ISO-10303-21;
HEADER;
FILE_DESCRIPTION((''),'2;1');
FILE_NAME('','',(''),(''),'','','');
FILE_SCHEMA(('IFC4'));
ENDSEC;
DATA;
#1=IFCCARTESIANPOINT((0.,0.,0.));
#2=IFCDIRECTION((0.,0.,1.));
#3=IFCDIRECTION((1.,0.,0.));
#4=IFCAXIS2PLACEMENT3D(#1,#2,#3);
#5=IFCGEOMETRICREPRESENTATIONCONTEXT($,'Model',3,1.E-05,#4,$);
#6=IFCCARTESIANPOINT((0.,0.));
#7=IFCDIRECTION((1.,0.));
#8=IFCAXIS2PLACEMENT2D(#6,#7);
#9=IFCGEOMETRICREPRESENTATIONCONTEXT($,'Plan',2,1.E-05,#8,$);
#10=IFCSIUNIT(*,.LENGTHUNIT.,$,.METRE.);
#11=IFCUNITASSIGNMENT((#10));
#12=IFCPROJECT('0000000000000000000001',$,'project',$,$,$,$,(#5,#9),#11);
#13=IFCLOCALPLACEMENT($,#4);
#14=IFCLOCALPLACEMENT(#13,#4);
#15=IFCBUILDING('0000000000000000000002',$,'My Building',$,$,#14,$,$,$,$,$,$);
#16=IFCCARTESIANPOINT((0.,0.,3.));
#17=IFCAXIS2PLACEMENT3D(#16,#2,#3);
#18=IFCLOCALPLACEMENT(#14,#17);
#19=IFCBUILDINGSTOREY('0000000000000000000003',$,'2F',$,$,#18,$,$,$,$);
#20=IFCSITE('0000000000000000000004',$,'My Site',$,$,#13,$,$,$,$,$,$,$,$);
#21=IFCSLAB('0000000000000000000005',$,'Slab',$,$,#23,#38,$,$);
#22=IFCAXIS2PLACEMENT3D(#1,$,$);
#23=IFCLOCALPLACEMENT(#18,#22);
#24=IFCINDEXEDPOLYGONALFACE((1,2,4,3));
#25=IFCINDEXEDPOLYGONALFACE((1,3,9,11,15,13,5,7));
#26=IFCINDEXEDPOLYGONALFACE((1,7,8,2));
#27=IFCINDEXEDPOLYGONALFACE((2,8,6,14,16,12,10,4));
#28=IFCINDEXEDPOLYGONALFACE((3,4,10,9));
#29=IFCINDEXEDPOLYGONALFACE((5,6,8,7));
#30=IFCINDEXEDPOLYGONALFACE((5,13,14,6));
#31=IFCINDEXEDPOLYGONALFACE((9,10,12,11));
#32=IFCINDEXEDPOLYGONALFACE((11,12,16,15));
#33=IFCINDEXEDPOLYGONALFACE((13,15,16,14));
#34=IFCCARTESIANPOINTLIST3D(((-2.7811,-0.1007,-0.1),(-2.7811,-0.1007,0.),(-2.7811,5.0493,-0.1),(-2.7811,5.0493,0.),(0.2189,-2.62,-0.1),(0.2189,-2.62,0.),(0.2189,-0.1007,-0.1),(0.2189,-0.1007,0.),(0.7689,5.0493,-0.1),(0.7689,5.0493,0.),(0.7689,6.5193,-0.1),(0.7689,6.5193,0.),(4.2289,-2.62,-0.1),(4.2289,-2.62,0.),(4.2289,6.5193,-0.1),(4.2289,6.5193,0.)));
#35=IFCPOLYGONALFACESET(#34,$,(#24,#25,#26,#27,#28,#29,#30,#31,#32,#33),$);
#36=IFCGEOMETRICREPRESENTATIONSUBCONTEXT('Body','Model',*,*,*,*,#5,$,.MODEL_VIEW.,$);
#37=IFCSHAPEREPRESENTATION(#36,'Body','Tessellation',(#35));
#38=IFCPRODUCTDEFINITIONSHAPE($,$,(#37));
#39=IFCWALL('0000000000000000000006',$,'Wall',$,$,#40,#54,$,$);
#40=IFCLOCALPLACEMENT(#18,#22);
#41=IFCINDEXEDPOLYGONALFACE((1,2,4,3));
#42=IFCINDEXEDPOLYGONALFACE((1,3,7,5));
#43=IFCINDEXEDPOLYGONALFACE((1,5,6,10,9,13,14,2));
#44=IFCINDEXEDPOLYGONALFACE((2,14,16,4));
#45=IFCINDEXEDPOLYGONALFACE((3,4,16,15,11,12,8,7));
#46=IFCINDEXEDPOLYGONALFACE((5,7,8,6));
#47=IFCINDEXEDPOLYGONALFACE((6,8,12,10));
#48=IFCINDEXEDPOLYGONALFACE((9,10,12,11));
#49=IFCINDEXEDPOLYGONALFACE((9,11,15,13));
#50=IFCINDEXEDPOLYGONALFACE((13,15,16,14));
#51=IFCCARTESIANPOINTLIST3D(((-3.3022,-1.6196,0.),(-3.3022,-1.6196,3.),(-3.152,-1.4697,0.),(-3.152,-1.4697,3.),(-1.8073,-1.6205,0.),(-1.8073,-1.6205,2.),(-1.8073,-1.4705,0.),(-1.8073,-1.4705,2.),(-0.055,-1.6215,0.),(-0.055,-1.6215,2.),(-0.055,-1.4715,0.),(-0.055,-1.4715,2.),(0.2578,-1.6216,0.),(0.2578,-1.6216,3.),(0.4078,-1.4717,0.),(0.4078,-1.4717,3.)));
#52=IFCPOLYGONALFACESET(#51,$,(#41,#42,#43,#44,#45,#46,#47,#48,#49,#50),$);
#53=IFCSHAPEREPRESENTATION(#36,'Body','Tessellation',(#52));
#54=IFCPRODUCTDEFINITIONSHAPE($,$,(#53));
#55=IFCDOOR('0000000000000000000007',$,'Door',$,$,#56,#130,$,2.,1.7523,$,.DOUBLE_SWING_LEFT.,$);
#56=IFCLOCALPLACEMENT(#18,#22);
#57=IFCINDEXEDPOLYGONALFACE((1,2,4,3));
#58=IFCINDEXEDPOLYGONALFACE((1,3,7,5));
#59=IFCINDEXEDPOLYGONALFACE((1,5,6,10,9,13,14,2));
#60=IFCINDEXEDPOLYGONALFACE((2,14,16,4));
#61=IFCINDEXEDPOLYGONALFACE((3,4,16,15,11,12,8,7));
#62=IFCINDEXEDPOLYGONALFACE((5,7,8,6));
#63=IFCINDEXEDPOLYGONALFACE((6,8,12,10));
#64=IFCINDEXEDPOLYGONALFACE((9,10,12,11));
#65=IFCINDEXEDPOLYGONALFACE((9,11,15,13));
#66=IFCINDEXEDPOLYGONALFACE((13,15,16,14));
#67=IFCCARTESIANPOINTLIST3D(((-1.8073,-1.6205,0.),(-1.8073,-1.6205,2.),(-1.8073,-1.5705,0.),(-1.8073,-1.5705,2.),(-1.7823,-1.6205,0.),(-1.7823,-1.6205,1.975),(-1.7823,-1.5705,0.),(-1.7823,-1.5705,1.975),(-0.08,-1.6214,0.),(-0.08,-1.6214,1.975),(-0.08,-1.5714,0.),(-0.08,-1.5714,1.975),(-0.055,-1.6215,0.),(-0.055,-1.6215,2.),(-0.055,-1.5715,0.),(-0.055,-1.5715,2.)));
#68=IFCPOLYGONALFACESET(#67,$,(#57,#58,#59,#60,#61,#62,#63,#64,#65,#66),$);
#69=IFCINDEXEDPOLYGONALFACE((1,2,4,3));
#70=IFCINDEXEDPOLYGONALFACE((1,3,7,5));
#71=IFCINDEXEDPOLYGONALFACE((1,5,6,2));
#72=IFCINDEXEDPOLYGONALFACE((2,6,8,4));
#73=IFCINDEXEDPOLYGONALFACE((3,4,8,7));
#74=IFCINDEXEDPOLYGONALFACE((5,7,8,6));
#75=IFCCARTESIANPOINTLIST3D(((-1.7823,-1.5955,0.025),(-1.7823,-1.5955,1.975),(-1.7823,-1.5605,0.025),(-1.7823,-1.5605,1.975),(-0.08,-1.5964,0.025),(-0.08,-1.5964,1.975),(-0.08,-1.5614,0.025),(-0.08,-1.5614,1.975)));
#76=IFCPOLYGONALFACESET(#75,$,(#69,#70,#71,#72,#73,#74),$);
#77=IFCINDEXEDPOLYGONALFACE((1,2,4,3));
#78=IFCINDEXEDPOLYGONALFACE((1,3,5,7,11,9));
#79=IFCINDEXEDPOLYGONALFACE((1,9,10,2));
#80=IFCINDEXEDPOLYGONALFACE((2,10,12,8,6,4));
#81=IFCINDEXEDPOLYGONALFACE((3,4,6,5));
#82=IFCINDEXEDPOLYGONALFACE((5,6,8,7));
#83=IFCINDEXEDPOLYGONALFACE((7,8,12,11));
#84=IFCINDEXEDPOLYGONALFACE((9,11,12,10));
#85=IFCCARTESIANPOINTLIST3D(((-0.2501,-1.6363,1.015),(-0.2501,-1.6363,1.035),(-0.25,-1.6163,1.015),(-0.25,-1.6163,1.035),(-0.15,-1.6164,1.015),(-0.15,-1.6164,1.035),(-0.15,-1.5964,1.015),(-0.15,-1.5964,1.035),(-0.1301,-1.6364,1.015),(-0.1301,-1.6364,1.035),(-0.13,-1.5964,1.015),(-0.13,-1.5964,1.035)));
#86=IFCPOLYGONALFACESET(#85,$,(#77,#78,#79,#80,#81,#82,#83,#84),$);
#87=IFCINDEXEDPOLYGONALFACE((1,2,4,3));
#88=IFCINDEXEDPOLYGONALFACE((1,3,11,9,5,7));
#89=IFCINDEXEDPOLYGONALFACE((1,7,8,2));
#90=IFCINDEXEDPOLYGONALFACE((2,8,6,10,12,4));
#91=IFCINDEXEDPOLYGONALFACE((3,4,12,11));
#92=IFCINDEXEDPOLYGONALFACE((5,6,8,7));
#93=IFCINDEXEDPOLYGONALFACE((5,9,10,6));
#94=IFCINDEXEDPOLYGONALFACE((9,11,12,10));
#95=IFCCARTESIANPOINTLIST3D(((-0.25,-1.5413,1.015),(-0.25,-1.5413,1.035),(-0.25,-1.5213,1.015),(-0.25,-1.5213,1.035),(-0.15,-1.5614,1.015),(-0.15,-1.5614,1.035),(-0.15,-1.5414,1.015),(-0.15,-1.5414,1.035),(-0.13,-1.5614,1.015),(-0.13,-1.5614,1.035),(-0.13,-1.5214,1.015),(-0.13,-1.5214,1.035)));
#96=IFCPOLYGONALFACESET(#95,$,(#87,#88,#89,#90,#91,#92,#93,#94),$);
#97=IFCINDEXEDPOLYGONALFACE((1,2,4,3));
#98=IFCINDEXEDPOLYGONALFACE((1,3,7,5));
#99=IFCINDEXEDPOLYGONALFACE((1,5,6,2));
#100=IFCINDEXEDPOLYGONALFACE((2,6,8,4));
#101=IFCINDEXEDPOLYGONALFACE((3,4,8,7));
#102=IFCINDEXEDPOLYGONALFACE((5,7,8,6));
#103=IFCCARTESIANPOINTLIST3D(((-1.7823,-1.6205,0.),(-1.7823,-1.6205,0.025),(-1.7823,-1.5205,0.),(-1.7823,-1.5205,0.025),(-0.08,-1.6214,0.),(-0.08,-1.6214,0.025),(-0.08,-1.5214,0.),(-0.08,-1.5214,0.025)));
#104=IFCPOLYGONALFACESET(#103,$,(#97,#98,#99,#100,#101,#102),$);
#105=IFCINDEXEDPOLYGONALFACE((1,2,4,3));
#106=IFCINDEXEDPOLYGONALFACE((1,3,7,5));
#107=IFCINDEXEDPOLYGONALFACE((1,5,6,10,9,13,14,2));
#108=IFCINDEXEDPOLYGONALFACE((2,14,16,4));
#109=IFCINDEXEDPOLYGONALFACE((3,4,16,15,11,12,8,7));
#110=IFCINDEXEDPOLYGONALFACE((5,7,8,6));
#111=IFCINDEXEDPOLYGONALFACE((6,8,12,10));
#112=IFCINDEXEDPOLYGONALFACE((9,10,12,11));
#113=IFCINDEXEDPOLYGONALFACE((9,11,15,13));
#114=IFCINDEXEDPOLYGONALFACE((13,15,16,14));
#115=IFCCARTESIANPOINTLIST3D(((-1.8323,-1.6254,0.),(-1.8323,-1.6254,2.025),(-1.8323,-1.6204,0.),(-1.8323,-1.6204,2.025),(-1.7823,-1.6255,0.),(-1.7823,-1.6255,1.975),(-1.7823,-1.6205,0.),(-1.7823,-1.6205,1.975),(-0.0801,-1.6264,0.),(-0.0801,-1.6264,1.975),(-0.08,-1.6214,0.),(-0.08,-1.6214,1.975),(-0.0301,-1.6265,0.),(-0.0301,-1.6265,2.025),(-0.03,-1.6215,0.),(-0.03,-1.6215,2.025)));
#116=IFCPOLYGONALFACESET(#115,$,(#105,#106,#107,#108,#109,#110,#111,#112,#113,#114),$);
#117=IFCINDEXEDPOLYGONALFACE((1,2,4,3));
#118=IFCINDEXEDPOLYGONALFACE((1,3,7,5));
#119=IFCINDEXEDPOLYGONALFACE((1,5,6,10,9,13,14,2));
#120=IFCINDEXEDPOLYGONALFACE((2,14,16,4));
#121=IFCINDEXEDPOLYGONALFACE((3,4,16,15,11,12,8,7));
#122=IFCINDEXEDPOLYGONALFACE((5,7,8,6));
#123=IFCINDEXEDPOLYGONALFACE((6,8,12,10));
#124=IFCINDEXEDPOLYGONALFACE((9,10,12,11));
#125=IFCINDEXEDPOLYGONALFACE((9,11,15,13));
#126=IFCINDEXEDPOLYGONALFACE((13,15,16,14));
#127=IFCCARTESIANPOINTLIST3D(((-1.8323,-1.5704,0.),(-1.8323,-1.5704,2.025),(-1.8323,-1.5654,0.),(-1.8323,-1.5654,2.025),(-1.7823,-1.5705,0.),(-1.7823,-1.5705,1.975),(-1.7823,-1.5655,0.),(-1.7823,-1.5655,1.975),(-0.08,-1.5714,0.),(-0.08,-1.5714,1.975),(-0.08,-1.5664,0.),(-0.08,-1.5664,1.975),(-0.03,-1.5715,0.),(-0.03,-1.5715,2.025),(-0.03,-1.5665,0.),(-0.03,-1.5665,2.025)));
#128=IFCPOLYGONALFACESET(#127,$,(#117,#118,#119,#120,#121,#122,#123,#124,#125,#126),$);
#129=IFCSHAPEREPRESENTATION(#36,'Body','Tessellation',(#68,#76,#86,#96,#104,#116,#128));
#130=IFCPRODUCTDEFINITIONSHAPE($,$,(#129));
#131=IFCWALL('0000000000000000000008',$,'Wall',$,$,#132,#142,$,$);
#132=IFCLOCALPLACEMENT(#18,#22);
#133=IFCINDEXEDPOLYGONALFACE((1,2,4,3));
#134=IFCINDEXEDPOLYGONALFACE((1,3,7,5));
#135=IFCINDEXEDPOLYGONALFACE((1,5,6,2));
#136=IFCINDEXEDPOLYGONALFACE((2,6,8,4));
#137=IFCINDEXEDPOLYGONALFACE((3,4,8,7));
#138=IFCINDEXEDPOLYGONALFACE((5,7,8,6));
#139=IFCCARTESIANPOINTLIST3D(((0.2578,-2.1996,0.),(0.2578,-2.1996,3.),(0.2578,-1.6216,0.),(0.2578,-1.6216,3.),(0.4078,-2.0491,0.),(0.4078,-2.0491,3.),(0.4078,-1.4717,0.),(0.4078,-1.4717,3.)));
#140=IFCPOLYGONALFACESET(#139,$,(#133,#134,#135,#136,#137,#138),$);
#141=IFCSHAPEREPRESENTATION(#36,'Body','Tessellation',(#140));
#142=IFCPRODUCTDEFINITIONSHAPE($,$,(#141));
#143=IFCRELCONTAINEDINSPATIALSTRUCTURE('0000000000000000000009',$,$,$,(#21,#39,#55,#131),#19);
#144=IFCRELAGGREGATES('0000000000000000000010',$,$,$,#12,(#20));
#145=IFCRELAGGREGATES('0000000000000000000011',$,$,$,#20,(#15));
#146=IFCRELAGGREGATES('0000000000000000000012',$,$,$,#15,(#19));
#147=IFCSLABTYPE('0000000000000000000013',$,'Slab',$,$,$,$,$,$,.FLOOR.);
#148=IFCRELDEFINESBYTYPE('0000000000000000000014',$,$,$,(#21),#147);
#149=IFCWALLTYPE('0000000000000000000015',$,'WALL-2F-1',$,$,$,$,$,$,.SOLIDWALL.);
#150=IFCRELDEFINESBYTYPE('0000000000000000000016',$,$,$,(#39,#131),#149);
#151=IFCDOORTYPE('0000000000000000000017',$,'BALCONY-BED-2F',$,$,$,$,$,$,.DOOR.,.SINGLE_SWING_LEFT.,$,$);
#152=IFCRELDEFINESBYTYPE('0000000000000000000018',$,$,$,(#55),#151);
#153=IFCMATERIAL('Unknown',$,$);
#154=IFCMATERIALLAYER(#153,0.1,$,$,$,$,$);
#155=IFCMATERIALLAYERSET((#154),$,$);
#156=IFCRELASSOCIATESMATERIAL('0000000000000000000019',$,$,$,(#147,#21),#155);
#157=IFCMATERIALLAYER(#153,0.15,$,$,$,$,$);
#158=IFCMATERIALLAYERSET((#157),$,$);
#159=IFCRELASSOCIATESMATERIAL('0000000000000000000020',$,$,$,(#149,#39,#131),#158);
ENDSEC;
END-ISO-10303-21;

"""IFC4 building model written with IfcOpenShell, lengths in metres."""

from ifc_helpers import new_model, entity, si_unit, frame, origin_with_axes, origin_2d_with_axis, place, context, subcontext, project, spatial, line, indexed_curve, outline, extrude, shape, source, transform, mapped, material, layer, layer_set, layer_usage, type_object, type_shapes, element, fill, save


model = new_model("IFC4")

# Units and contexts
model_context = context("Model", 3, precision=1e-05, world=origin_with_axes())
plan_context = context("Plan", 2, precision=1e-05, world=origin_2d_with_axis())
body_context_1 = subcontext(model_context, "Body", "Model", "MODEL_VIEW")
body_context_2 = subcontext(plan_context, "Body", "Plan", "PLAN_VIEW")
ifc_project = project(units=[si_unit("LENGTHUNIT", "METRE")], contexts=[model_context, plan_context])

# Site, building, storey
site_placement = place(None, origin_with_axes())
site = spatial("IfcSite", under=ifc_project, at=site_placement, Name="My Site")
building_placement = place(site_placement, origin_with_axes())
building = spatial("IfcBuilding", under=site, at=building_placement, Name="My Building")
storey_placement = place(building_placement, frame((0.0, 0.0, 3.0), z_axis=(0.0, 0.0, 1.0), x_axis=(1.0, 0.0, 0.0)))
storey = spatial("IfcBuildingStorey", under=building, at=storey_placement, Name="2F")

# Slab
ifc_material = material(Name="Unknown")
ifc_layer_1 = layer(ifc_material, 0.1)
ifc_layer_set_1 = layer_set([ifc_layer_1])
ifc_layer_usage_1 = layer_usage(ifc_layer_set_1, "AXIS3", "POSITIVE", -0.1)
slab_type = type_object("IfcSlabType", Name="Slab", PredefinedType="FLOOR", material=ifc_layer_set_1)
slab_placement = place(storey_placement, frame((0.2189, -2.62, 0.0), z_axis=(0.0, 0.0, 1.0), x_axis=(1.0, 0.0, 0.0)))
element("IfcSlab", 1, at=slab_placement, inside=storey, type_object=slab_type, material=ifc_layer_usage_1, Name="Slab", context=body_context_1, shape_type="SweptSolid", body=[
    extrude(outline(indexed_curve([(0.0, 0.0), (4.01, 0.0), (4.01, 9.1393), (0.55, 9.1393), (0.55, 7.6693), (-3.0, 7.6693), (-3.0, 2.5193), (0.0, 2.5193), (0.0, 0.0)])), frame((0.0, 0.0, -0.1), z_axis=(0.0, 0.0, 1.0), x_axis=(1.0, 0.0, 0.0)), (0.0, 0.0, 1.0), 0.1),
])

# Wall, opening, door
ifc_layer_2 = layer(ifc_material, 0.15)
ifc_layer_set_2 = layer_set([ifc_layer_2])
ifc_layer_usage_2 = layer_usage(ifc_layer_set_2, "AXIS2", "POSITIVE", 0.0)
wall_type_1 = type_object("IfcWallType", Name="WALL-2F-1", PredefinedType="SOLIDWALL", material=ifc_layer_set_2)
wall_1_placement = place(storey_placement, frame((-3.3022, -1.6196, 0.0), z_axis=(0.0, 0.0, 1.0), x_axis=(1.0, -0.00057, 0.0)))
wall_1 = element("IfcWall", 2, at=wall_1_placement, inside=storey, type_object=wall_type_1, material=ifc_layer_usage_2, Name="Wall", context=body_context_1, shape_type="SweptSolid", body=[
    extrude(outline(indexed_curve([(0.0, 0.0), (0.1501, 0.15), (3.7099, 0.15), (3.56, 0.0)], segments=[line(1, 2, 3, 4, 1)])), origin_with_axes(), (0.0, 0.0, 1.0), 3.0),
])
shared_shape_1 = source(origin_with_axes(), body_context_1, "Body", "SweptSolid", [
    extrude(outline(indexed_curve([(0.0, 0.0), (1.7523, 0.0), (1.7523, 2.0), (0.0, 2.0)], segments=[line(1, 2, 3, 4, 1)])), frame((0.0, -0.6, 0.0), z_axis=(0.0, -1.0, 0.0), x_axis=(1.0, 0.0, 0.0)), (0.0, 0.0, -1.0), 1.2),
])
opening_1_placement = place(wall_1_placement, frame((1.4948, 0.0, 0.0), z_axis=(0.0, 0.0, 1.0), x_axis=(1.0, 0.0, 0.0)))
opening_1 = element("IfcOpeningElement", 3, at=opening_1_placement, cuts=wall_1, PredefinedType="OPENING", context=body_context_1, shape_type="MappedRepresentation", body=[
    mapped(shared_shape_1, transform((0.0, 0.0, 0.0), x_axis=(1.0, 0.0, 0.0), y_axis=(0.0, 1.0, 0.0), z_axis=(0.0, 0.0, 1.0), scale=1.0)),
])
door_type_1 = type_object("IfcDoorType", Name="BALCONY-BED-2F", OperationType="SINGLE_SWING_LEFT", PredefinedType="DOOR")
shared_shape_2 = source(origin_with_axes(), body_context_1, "Body", "SweptSolid", [
    extrude(outline(indexed_curve([(0.0, 0.0), (0.0, 2.0), (1.7523, 2.0), (1.7523, 0.0), (1.7273, 0.0), (1.7273, 1.975), (0.025, 1.975), (0.025, 0.0)], segments=[line(1, 2, 3, 4, 5, 6, 7, 8, 1)])), frame((0.0, 0.0, 0.0), z_axis=(0.0, -1.0, 0.0), x_axis=(1.0, 0.0, 0.0)), (0.0, 0.0, -1.0), 0.05),
    extrude(outline(indexed_curve([(0.0, 0.0), (1.7023, 0.0), (1.7023, 0.035), (0.0, 0.035)], segments=[line(1, 2, 3, 4, 1)])), frame((0.025, 0.025, 0.025), z_axis=(0.0, 0.0, 1.0), x_axis=(1.0, 0.0, 0.0)), (0.0, 0.0, 1.0), 1.95),
    extrude(outline(indexed_curve([(0.0, 0.0), (0.0, -0.04), (-0.12, -0.04), (-0.12, -0.02), (-0.02, -0.02), (-0.02, 0.0)], segments=[line(1, 2, 3, 4, 5, 6, 1)])), frame((1.6773, 0.025, 1.015), z_axis=(0.0, 0.0, 1.0), x_axis=(1.0, 0.0, 0.0)), (0.0, 0.0, 1.0), 0.02),
    extrude(outline(indexed_curve([(0.0, 0.0), (0.0, 0.04), (-0.12, 0.04), (-0.12, 0.02), (-0.02, 0.02), (-0.02, 0.0)], segments=[line(1, 2, 3, 4, 5, 6, 1)])), frame((1.6773, 0.06, 1.015), z_axis=(0.0, 0.0, 1.0), x_axis=(1.0, 0.0, 0.0)), (0.0, 0.0, 1.0), 0.02),
    extrude(outline(indexed_curve([(0.0, 0.0), (1.7023, 0.0), (1.7023, 0.1), (0.0, 0.1)], segments=[line(1, 2, 3, 4, 1)])), frame((0.025, 0.0, 0.0), z_axis=(0.0, 0.0, 1.0), x_axis=(1.0, 0.0, 0.0)), (0.0, 0.0, 1.0), 0.025),
    extrude(outline(indexed_curve([(0.0, 0.0), (0.0, 2.025), (1.8023, 2.025), (1.8023, 0.0), (1.7523, 0.0), (1.7523, 1.975), (0.05, 1.975), (0.05, 0.0)], segments=[line(1, 2, 3, 4, 5, 6, 7, 8, 1)])), frame((-0.025, -0.005, 0.0), z_axis=(0.0, -1.0, 0.0), x_axis=(1.0, 0.0, 0.0)), (0.0, 0.0, -1.0), 0.005),
    extrude(outline(indexed_curve([(0.0, 0.0), (0.0, 2.025), (1.8023, 2.025), (1.8023, 0.0), (1.7523, 0.0), (1.7523, 1.975), (0.05, 1.975), (0.05, 0.0)], segments=[line(1, 2, 3, 4, 5, 6, 7, 8, 1)])), frame((-0.025, 0.05, 0.0), z_axis=(0.0, -1.0, 0.0), x_axis=(1.0, 0.0, 0.0)), (0.0, 0.0, -1.0), 0.005),
])
shared_shape_3 = source(origin_with_axes(), body_context_2, "Body", "Curve2D", [
    entity("IfcIndexedPolyCurve", entity("IfcCartesianPointList2D", [[0.0, 0.0], [0.025, 0.0], [0.025, 0.05], [0.0, 0.05]]), [entity("IfcLineIndex", [1, 2, 3, 4, 1])]),
    entity("IfcIndexedPolyCurve", entity("IfcCartesianPointList2D", [[1.7523, 0.0], [1.7273, 0.0], [1.7273, 0.05], [1.7523, 0.05]]), [entity("IfcLineIndex", [1, 2, 3, 4, 1])]),
    entity("IfcIndexedPolyCurve", entity("IfcCartesianPointList2D", [[0.025, 0.05], [0.025, -1.6523], [0.06, -1.6523]])),
    entity("IfcTrimmedCurve", entity("IfcEllipse", entity("IfcAxis2Placement2D", entity("IfcCartesianPoint", [0.06, 0.05]), entity("IfcDirection", [1.0, 0.0])), 1.6673, 1.7023), [entity("IfcCartesianPoint", [0.06, -1.6523])], [entity("IfcCartesianPoint", [0.06, 1.7523])], True, "CARTESIAN"),
    entity("IfcIndexedPolyCurve", entity("IfcCartesianPointList2D", [[0.025, 0.05], [0.06, 0.05], [0.06, 1.7523], [0.025, 1.7523]]), [entity("IfcLineIndex", [1, 2, 3, 4, 1])]),
])
type_shapes(door_type_1, [shared_shape_2, shared_shape_3])
door_1_placement = place(opening_1_placement, frame((0.0, 0.0, 0.0), z_axis=(0.0, 0.0, 1.0), x_axis=(1.0, 0.0, 0.0)))
door_1 = element("IfcDoor", 4, at=door_1_placement, inside=storey, type_object=door_type_1, Name="Door", OperationType="DOUBLE_SWING_LEFT", OverallHeight=2.0, OverallWidth=1.7523, shapes=[
    shape(body_context_1, "Body", "MappedRepresentation", [mapped(shared_shape_2, transform((0.0, 0.0, 0.0), x_axis=(1.0, 0.0, 0.0), y_axis=(0.0, 1.0, 0.0), z_axis=(0.0, 0.0, 1.0), scale=1.0))]),
    shape(body_context_2, "Body", "MappedRepresentation", [mapped(shared_shape_3, transform((0.0, 0.0, 0.0), x_axis=(1.0, 0.0, 0.0), y_axis=(0.0, 1.0, 0.0), z_axis=(0.0, 0.0, 1.0), scale=1.0))]),
])
fill(opening_1, door_1)

# Wall
ifc_layer_usage_3 = layer_usage(ifc_layer_set_2, "AXIS2", "POSITIVE", 0.0)
wall_2_placement = place(storey_placement, frame((0.2578, -1.6216, 0.0), z_axis=(0.0, 0.0, 1.0), x_axis=(0.0, -1.0, 0.0)))
element("IfcWall", 5, at=wall_2_placement, inside=storey, type_object=wall_type_1, material=ifc_layer_usage_3, Name="Wall", context=body_context_1, shape_type="SweptSolid", body=[
    extrude(outline(indexed_curve([(0.0, 0.0), (-0.1499, 0.15), (0.4275, 0.15), (0.578, 0.0)], segments=[line(1, 2, 3, 4, 1)])), origin_with_axes(), (0.0, 0.0, 1.0), 3.0),
])

save(model, "model.ifc")
